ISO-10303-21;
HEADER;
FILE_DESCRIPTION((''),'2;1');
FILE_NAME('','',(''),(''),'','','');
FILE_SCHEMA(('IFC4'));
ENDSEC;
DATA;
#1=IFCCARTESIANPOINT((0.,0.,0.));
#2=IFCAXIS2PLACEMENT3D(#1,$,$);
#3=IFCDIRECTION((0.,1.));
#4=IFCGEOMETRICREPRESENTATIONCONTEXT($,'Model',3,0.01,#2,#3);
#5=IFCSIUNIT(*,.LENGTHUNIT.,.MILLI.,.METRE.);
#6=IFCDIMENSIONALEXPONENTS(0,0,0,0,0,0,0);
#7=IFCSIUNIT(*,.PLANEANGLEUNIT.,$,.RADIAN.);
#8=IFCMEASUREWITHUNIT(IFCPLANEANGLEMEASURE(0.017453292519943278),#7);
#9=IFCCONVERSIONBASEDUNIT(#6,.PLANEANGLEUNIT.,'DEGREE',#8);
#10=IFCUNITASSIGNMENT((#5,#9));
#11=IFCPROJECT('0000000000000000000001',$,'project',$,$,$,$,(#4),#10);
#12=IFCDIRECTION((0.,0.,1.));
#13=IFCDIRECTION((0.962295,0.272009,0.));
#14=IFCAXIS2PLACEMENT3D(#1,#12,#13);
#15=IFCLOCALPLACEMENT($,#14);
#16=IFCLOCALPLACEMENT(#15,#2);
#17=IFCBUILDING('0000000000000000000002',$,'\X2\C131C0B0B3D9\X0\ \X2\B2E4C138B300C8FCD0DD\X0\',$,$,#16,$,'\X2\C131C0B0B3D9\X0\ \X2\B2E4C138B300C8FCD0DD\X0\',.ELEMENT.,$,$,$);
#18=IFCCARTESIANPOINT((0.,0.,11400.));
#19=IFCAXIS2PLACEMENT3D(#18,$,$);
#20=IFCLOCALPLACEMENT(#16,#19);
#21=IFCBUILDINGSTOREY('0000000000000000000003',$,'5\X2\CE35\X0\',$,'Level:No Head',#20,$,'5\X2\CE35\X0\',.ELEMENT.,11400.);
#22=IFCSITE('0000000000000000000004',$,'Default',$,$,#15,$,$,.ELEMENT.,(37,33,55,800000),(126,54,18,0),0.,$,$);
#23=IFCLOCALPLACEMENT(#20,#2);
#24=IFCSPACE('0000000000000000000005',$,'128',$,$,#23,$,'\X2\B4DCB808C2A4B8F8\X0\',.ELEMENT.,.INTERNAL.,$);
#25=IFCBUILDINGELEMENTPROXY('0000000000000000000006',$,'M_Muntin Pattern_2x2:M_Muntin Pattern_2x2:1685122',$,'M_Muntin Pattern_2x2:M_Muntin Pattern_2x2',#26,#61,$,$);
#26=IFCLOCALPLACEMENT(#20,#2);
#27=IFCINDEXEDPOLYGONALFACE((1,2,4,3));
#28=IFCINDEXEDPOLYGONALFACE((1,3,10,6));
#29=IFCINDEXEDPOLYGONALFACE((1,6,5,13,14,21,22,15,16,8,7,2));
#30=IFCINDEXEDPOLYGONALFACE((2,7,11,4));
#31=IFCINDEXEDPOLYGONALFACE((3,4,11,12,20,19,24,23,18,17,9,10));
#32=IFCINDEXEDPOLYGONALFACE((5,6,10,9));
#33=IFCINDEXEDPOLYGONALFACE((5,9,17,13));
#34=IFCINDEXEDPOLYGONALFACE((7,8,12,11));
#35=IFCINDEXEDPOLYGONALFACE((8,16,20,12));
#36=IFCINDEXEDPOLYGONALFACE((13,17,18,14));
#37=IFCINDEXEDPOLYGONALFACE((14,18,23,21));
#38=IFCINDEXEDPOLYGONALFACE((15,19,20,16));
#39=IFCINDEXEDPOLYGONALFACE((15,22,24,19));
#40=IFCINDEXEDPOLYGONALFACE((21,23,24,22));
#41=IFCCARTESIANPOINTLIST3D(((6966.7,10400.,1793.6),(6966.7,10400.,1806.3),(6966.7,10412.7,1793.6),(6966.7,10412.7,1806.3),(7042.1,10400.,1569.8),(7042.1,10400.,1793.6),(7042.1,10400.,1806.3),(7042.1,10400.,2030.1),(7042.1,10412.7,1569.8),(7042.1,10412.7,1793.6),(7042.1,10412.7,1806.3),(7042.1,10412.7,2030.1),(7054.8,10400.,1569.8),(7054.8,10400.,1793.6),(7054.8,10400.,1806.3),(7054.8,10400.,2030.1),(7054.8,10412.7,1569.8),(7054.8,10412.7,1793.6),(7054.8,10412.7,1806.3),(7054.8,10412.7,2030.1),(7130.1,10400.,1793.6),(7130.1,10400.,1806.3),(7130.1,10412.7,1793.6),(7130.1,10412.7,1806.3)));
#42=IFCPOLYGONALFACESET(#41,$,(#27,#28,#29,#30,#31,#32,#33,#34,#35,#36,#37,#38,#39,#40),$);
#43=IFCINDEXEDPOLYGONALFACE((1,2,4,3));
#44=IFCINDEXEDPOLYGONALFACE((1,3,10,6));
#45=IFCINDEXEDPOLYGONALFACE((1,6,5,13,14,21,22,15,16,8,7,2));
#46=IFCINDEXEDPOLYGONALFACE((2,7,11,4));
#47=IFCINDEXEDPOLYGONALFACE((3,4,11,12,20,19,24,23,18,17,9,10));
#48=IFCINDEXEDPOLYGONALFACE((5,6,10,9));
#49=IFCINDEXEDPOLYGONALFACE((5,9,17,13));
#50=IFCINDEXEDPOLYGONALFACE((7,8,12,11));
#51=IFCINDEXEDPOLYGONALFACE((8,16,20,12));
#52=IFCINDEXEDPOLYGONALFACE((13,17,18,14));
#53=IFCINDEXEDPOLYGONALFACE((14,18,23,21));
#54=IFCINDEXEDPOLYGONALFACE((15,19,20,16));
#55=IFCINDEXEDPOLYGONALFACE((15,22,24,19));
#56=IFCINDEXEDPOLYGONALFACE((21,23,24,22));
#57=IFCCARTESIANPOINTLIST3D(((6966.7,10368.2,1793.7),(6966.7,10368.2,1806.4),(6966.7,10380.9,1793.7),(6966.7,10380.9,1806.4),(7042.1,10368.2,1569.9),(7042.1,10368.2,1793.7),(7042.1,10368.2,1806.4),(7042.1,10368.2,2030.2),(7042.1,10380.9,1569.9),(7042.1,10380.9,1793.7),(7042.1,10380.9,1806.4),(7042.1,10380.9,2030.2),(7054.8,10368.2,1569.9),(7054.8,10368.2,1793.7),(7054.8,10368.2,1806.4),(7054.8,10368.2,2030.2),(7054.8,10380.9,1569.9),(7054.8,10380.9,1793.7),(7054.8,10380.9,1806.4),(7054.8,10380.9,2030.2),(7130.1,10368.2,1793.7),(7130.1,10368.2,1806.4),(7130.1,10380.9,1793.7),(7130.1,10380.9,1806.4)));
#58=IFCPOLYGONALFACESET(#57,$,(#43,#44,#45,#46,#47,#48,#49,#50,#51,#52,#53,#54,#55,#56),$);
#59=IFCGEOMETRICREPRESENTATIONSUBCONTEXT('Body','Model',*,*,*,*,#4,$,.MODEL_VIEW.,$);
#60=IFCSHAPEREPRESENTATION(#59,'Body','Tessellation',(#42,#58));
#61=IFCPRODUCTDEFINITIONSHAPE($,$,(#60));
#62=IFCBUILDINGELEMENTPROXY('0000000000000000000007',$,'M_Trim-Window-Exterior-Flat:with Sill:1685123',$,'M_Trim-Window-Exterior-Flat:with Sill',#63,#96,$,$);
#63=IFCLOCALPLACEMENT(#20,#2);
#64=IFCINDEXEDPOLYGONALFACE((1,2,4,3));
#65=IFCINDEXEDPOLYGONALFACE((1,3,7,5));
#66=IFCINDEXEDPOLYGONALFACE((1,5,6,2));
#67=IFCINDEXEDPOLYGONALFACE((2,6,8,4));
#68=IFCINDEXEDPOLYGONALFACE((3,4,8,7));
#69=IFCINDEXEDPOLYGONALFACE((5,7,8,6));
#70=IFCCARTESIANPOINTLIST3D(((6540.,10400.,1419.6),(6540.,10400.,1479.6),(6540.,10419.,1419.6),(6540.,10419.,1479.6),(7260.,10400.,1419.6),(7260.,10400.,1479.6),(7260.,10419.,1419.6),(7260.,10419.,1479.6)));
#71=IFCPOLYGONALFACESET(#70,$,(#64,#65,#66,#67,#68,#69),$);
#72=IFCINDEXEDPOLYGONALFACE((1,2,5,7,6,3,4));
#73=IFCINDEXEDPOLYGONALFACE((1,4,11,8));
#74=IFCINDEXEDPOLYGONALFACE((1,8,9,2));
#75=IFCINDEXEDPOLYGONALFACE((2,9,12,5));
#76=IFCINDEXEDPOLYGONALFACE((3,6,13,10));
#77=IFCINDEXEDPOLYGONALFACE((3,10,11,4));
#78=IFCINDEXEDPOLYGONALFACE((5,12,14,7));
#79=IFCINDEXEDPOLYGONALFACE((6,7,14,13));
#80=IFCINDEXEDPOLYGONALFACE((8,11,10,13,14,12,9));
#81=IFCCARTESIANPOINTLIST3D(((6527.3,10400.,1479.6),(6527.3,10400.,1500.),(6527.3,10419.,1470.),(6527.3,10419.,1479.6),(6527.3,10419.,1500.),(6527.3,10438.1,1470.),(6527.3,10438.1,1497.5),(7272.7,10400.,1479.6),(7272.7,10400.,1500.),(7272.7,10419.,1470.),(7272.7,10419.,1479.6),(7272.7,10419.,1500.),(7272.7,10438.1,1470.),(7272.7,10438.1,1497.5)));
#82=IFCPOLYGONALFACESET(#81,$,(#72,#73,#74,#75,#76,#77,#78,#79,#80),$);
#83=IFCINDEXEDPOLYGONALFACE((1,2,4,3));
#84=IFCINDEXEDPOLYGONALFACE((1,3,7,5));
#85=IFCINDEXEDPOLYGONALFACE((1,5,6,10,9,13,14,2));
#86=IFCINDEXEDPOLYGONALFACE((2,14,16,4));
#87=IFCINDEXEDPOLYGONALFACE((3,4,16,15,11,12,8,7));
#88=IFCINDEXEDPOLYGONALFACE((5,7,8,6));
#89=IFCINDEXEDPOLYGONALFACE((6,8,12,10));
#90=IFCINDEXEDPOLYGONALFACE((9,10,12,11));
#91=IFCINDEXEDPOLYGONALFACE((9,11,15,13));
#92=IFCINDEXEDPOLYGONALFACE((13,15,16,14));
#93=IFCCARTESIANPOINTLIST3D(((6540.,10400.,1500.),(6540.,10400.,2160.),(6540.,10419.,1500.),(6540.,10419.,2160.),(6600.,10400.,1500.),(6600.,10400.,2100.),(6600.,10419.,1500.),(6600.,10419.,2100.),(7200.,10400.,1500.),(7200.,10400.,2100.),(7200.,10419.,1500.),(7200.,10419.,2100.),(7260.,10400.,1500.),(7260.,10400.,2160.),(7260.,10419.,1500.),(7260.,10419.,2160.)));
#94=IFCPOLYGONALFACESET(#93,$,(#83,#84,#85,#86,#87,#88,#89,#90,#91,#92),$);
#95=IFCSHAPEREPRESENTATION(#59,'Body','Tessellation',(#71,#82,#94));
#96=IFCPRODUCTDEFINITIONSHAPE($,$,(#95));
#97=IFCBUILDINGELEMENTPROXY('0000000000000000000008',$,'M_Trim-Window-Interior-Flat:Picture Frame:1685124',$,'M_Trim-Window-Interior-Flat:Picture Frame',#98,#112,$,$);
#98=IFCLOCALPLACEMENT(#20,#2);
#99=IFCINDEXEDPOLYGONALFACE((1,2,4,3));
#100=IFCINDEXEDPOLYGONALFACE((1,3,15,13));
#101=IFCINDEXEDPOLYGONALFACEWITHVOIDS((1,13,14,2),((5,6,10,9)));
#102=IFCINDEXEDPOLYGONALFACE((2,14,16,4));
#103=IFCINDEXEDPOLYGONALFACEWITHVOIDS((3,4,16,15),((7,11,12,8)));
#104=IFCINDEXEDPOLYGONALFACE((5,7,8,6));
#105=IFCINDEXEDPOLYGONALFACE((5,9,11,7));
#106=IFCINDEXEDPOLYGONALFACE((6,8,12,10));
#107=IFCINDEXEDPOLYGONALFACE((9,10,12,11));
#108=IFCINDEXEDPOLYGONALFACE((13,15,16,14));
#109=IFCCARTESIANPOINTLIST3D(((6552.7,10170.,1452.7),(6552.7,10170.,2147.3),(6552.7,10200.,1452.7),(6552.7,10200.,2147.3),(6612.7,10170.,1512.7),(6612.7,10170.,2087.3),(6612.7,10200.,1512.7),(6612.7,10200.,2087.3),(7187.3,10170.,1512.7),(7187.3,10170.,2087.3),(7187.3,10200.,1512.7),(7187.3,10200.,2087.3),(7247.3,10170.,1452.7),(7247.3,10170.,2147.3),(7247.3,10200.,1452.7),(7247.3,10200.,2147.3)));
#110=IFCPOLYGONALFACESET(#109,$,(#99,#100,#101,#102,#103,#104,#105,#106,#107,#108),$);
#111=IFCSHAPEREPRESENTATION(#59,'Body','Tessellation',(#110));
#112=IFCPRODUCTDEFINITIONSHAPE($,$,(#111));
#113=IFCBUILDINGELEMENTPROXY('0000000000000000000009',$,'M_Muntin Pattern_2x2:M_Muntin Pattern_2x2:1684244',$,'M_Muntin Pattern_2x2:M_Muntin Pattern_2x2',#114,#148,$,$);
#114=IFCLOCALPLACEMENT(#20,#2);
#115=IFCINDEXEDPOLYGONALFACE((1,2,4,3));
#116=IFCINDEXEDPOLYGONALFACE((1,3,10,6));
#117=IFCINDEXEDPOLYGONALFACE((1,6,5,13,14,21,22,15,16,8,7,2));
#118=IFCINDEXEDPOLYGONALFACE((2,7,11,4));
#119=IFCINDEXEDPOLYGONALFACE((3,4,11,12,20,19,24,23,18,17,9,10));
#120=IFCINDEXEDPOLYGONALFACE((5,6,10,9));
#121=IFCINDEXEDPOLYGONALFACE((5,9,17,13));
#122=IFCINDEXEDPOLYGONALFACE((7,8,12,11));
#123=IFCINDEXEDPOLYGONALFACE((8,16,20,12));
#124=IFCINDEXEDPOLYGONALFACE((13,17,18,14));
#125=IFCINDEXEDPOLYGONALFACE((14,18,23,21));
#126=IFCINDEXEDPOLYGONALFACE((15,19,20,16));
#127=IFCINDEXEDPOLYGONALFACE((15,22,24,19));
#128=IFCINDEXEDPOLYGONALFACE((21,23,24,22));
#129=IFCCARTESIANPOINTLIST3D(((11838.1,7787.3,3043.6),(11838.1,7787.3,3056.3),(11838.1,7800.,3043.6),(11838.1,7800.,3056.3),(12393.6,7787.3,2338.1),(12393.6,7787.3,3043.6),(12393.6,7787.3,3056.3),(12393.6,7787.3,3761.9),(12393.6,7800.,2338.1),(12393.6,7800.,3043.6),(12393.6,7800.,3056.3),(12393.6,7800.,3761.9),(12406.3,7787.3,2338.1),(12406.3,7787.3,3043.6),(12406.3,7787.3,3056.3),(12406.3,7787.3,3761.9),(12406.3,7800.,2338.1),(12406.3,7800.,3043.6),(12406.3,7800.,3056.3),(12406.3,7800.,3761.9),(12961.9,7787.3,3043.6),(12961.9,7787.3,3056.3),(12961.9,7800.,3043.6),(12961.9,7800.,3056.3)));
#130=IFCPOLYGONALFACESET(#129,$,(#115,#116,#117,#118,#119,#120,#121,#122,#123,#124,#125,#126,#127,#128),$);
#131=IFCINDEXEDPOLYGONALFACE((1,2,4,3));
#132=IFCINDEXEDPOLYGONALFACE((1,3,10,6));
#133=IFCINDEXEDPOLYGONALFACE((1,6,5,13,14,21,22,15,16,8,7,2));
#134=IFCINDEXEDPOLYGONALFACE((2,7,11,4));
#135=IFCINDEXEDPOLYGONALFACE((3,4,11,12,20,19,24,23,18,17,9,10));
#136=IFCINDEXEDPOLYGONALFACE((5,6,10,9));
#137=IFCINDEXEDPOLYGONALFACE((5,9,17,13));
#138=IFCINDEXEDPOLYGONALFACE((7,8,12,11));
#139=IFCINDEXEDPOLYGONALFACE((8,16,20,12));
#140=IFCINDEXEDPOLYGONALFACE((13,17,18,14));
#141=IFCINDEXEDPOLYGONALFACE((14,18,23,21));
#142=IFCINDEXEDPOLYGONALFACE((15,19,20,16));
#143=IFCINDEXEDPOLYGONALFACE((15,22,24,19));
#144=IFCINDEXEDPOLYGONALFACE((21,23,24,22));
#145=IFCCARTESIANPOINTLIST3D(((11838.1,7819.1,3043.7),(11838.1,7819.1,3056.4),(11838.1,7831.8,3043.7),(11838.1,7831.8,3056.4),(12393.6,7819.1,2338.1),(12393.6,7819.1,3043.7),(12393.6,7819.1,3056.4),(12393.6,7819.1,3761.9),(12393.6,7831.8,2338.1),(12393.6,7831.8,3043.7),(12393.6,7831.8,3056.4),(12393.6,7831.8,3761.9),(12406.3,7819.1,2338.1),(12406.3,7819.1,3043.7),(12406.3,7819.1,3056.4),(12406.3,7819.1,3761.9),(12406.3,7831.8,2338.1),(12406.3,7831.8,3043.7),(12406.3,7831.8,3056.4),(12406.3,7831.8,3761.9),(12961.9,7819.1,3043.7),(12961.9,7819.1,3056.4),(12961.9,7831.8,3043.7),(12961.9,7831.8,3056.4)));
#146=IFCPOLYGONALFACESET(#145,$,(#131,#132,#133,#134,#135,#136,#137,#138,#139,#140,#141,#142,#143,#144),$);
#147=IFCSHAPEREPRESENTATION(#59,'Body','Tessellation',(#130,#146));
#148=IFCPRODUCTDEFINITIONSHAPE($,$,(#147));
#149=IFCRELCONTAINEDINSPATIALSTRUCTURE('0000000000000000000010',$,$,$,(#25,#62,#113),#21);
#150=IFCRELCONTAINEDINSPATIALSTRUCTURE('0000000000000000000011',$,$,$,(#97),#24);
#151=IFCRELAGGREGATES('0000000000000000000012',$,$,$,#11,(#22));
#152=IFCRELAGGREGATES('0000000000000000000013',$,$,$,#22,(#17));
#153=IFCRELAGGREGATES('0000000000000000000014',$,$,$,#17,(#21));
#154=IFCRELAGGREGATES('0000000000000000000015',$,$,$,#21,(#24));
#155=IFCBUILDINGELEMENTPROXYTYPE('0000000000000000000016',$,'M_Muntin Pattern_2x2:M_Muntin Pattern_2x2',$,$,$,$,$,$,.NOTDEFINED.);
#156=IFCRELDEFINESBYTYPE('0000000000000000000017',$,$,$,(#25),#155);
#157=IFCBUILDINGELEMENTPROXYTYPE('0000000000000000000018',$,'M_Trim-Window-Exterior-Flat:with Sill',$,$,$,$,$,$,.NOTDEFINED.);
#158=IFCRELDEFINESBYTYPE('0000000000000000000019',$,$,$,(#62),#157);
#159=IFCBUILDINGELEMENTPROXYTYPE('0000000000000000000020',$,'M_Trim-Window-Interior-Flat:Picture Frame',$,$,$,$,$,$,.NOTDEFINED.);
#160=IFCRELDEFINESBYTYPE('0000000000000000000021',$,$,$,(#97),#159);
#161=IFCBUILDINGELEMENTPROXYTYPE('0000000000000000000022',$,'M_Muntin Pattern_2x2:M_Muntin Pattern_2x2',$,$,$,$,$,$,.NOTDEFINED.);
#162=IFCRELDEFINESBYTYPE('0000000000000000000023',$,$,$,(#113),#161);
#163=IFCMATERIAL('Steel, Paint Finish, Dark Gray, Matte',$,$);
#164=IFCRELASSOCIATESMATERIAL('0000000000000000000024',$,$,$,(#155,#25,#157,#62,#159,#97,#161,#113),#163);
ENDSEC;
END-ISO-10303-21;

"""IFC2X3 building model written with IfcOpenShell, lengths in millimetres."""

from ifc_helpers import new_model, entity, si_unit, converted_unit, direction, frame, frame_2d, origin, place, context, subcontext, project, spatial, polyline, rectangle, outline, extrude, source, transform, mapped, material, type_object, type_shapes, element, save


model = new_model("IFC2X3")

# Units and contexts
model_context = context("Model", 3, precision=0.01, world=origin(), true_north=direction((0.0, 1.0)))
body_context = subcontext(model_context, "Body", "Model", "MODEL_VIEW")
ifc_project = project(units=[si_unit("LENGTHUNIT", "METRE", prefix="MILLI"), converted_unit("PLANEANGLEUNIT", "DEGREE", entity("IfcPlaneAngleMeasure", 0.017453292519943278), si_unit("PLANEANGLEUNIT", "RADIAN"), dimensions=[0, 0, 0, 0, 0, 0, 0])], contexts=[model_context])

# Site, building, storey
site_placement = place(None, frame((0.0, 0.0, 0.0), z_axis=(0.0, 0.0, 1.0), x_axis=(0.962295, 0.272009, 0.0)))
site = spatial("IfcSite", under=ifc_project, at=site_placement, Name="Default", CompositionType="ELEMENT", RefLatitude=(37, 33, 55, 800000), RefLongitude=(126, 54, 18, 0), RefElevation=0.0)
building_placement = place(site_placement, origin())
building = spatial("IfcBuilding", under=site, at=building_placement, Name="성산동 다세대주택", LongName="성산동 다세대주택", CompositionType="ELEMENT")
storey_placement = place(building_placement, frame((0.0, 0.0, 11400.0)))
storey = spatial("IfcBuildingStorey", under=building, at=storey_placement, Name="5층", ObjectType="Level:No Head", LongName="5층", CompositionType="ELEMENT", Elevation=11400.0)

# Shared definitions
space_1_placement = place(storey_placement, origin())
space_1 = spatial("IfcSpace", under=storey, at=space_1_placement, Name="128", LongName="드레스룸", CompositionType="ELEMENT", InteriorOrExteriorSpace="INTERNAL")

# Building element proxies
ifc_material_1 = material(Name="Steel, Paint Finish, Dark Gray, Matte")
building_element_proxy_type_1 = type_object("IfcBuildingElementProxyType", Name="M_Muntin Pattern_2x2:M_Muntin Pattern_2x2", PredefinedType="NOTDEFINED", material=ifc_material_1)
shared_shape_1 = source(origin(), body_context, "Body", "SweptSolid", [
    extrude(outline(polyline([(6.4, -6.4), (230.1, -6.4), (230.1, 6.3), (6.4, 6.3), (6.4, 81.7), (-6.3, 81.7), (-6.3, 6.3), (-230.2, 6.3), (-230.2, -6.4), (-6.3, -6.4), (-6.3, -81.7), (6.4, -81.7), (6.4, -6.4)])), frame((0.0, -22.2, 230.1), z_axis=(0.0, 1.0, 0.0), x_axis=(0.0, 0.0, 1.0)), (0.0, 0.0, 1.0), 12.7),
    extrude(outline(polyline([(6.4, -6.4), (230.2, -6.4), (230.2, 6.3), (6.4, 6.3), (6.4, 81.7), (-6.3, 81.7), (-6.3, 6.3), (-230.2, 6.3), (-230.2, -6.4), (-6.3, -6.4), (-6.3, -81.7), (6.4, -81.7), (6.4, -6.4)])), frame((0.0, 9.5, 230.2), z_axis=(0.0, 1.0, 0.0), x_axis=(0.0, 0.0, 1.0)), (0.0, 0.0, 1.0), 12.7),
])
type_shapes(building_element_proxy_type_1, [shared_shape_1])
proxy_1_placement = place(storey_placement, frame((7048.4, 10390.5, 1569.9), z_axis=(0.0, 0.0, 1.0), x_axis=(-1.0, 0.0, 0.0)))
element("IfcBuildingElementProxy", 1, at=proxy_1_placement, inside=storey, type_object=building_element_proxy_type_1, material=ifc_material_1, Name="M_Muntin Pattern_2x2:M_Muntin Pattern_2x2:1685122", ObjectType="M_Muntin Pattern_2x2:M_Muntin Pattern_2x2", context=body_context, shape_type="MappedRepresentation", body=[
    mapped(shared_shape_1, transform((0.0, 0.0, 0.0), scale=1.0)),
])
building_element_proxy_type_2 = type_object("IfcBuildingElementProxyType", Name="M_Trim-Window-Exterior-Flat:with Sill", PredefinedType="NOTDEFINED", material=ifc_material_1)
shared_shape_2 = source(origin(), body_context, "Body", "SweptSolid", [
    extrude(rectangle(XDim=720.0, YDim=60.0, at=frame_2d((0.0, 0.0), x_axis=(1.0, 0.0))), frame((0.0, -650.4, 0.0), z_axis=(0.0, 0.0, 1.0), x_axis=(-1.0, 0.0, 0.0)), (0.0, 0.0, 1.0), 19.0),
    extrude(outline(polyline([(-19.0, -15.2), (0.0, -15.2), (0.0, -5.7), (19.0, -5.7), (19.0, 14.8), (0.0, 14.8), (-19.0, 12.3), (-19.0, -15.2)])), frame((-372.7, -614.8, 19.0), z_axis=(1.0, 0.0, 0.0), x_axis=(0.0, 0.0, -1.0)), (0.0, 0.0, 1.0), 745.4),
    extrude(outline(polyline([(-345.0, -360.0), (315.0, -360.0), (315.0, -300.0), (-285.0, -300.0), (-285.0, 300.0), (315.0, 300.0), (315.0, 360.0), (-345.0, 360.0), (-345.0, -360.0)])), frame((0.0, -285.0, 0.0), z_axis=(0.0, 0.0, 1.0), x_axis=(0.0, -1.0, 0.0)), (0.0, 0.0, 1.0), 19.0),
])
type_shapes(building_element_proxy_type_2, [shared_shape_2])
proxy_2_placement = place(storey_placement, frame((6900.0, 10400.0, 2100.0), z_axis=(0.0, 1.0, 0.0), x_axis=(-1.0, 0.0, 0.0)))
element("IfcBuildingElementProxy", 2, at=proxy_2_placement, inside=storey, type_object=building_element_proxy_type_2, material=ifc_material_1, Name="M_Trim-Window-Exterior-Flat:with Sill:1685123", ObjectType="M_Trim-Window-Exterior-Flat:with Sill", context=body_context, shape_type="MappedRepresentation", body=[
    mapped(shared_shape_2, transform((0.0, 0.0, 0.0), scale=1.0)),
])
building_element_proxy_type_3 = type_object("IfcBuildingElementProxyType", Name="M_Trim-Window-Interior-Flat:Picture Frame", PredefinedType="NOTDEFINED", material=ifc_material_1)
shared_shape_3 = source(origin(), body_context, "Body", "SweptSolid", [
    extrude(outline(polyline([(-347.3, -347.3), (347.3, -347.3), (347.3, 347.3), (-347.3, 347.3), (-347.3, -347.3)]), holes=[polyline([(-287.3, -287.3), (-287.3, 287.3), (287.3, 287.3), (287.3, -287.3), (-287.3, -287.3)])]), frame((0.0, -300.0, 0.0), z_axis=(0.0, 0.0, 1.0), x_axis=(-1.0, 0.0, 0.0)), (0.0, 0.0, 1.0), 30.0),
])
type_shapes(building_element_proxy_type_3, [shared_shape_3])
proxy_3_placement = place(space_1_placement, frame((6900.0, 10200.0, 2100.0), z_axis=(0.0, -1.0, 0.0), x_axis=(1.0, 0.0, 0.0)))
element("IfcBuildingElementProxy", 3, at=proxy_3_placement, inside=space_1, type_object=building_element_proxy_type_3, material=ifc_material_1, Name="M_Trim-Window-Interior-Flat:Picture Frame:1685124", ObjectType="M_Trim-Window-Interior-Flat:Picture Frame", context=body_context, shape_type="MappedRepresentation", body=[
    mapped(shared_shape_3, transform((0.0, 0.0, 0.0), scale=1.0)),
])
building_element_proxy_type_4 = type_object("IfcBuildingElementProxyType", Name="M_Muntin Pattern_2x2:M_Muntin Pattern_2x2", PredefinedType="NOTDEFINED", material=ifc_material_1)
shared_shape_4 = source(origin(), body_context, "Body", "SweptSolid", [
    extrude(outline(polyline([(6.4, -6.4), (711.9, -6.4), (711.9, 6.3), (6.4, 6.3), (6.4, 561.9), (-6.3, 561.9), (-6.3, 6.3), (-711.9, 6.3), (-711.9, -6.4), (-6.3, -6.4), (-6.3, -561.9), (6.4, -561.9), (6.4, -6.4)])), frame((0.0, -22.2, 711.9), z_axis=(0.0, 1.0, 0.0), x_axis=(0.0, 0.0, 1.0)), (0.0, 0.0, 1.0), 12.7),
    extrude(outline(polyline([(6.4, -6.4), (711.9, -6.4), (711.9, 6.3), (6.4, 6.3), (6.4, 561.9), (-6.3, 561.9), (-6.3, 6.3), (-711.9, 6.3), (-711.9, -6.4), (-6.3, -6.4), (-6.3, -561.9), (6.4, -561.9), (6.4, -6.4)])), frame((0.0, 9.5, 711.9), z_axis=(0.0, 1.0, 0.0), x_axis=(0.0, 0.0, 1.0)), (0.0, 0.0, 1.0), 12.7),
])
type_shapes(building_element_proxy_type_4, [shared_shape_4])
proxy_4_placement = place(storey_placement, frame((12400.0, 7809.5, 2338.1)))
element("IfcBuildingElementProxy", 4, at=proxy_4_placement, inside=storey, type_object=building_element_proxy_type_4, material=ifc_material_1, Name="M_Muntin Pattern_2x2:M_Muntin Pattern_2x2:1684244", ObjectType="M_Muntin Pattern_2x2:M_Muntin Pattern_2x2", context=body_context, shape_type="MappedRepresentation", body=[
    mapped(shared_shape_4, transform((0.0, 0.0, 0.0), scale=1.0)),
])

save(model, "model.ifc")
